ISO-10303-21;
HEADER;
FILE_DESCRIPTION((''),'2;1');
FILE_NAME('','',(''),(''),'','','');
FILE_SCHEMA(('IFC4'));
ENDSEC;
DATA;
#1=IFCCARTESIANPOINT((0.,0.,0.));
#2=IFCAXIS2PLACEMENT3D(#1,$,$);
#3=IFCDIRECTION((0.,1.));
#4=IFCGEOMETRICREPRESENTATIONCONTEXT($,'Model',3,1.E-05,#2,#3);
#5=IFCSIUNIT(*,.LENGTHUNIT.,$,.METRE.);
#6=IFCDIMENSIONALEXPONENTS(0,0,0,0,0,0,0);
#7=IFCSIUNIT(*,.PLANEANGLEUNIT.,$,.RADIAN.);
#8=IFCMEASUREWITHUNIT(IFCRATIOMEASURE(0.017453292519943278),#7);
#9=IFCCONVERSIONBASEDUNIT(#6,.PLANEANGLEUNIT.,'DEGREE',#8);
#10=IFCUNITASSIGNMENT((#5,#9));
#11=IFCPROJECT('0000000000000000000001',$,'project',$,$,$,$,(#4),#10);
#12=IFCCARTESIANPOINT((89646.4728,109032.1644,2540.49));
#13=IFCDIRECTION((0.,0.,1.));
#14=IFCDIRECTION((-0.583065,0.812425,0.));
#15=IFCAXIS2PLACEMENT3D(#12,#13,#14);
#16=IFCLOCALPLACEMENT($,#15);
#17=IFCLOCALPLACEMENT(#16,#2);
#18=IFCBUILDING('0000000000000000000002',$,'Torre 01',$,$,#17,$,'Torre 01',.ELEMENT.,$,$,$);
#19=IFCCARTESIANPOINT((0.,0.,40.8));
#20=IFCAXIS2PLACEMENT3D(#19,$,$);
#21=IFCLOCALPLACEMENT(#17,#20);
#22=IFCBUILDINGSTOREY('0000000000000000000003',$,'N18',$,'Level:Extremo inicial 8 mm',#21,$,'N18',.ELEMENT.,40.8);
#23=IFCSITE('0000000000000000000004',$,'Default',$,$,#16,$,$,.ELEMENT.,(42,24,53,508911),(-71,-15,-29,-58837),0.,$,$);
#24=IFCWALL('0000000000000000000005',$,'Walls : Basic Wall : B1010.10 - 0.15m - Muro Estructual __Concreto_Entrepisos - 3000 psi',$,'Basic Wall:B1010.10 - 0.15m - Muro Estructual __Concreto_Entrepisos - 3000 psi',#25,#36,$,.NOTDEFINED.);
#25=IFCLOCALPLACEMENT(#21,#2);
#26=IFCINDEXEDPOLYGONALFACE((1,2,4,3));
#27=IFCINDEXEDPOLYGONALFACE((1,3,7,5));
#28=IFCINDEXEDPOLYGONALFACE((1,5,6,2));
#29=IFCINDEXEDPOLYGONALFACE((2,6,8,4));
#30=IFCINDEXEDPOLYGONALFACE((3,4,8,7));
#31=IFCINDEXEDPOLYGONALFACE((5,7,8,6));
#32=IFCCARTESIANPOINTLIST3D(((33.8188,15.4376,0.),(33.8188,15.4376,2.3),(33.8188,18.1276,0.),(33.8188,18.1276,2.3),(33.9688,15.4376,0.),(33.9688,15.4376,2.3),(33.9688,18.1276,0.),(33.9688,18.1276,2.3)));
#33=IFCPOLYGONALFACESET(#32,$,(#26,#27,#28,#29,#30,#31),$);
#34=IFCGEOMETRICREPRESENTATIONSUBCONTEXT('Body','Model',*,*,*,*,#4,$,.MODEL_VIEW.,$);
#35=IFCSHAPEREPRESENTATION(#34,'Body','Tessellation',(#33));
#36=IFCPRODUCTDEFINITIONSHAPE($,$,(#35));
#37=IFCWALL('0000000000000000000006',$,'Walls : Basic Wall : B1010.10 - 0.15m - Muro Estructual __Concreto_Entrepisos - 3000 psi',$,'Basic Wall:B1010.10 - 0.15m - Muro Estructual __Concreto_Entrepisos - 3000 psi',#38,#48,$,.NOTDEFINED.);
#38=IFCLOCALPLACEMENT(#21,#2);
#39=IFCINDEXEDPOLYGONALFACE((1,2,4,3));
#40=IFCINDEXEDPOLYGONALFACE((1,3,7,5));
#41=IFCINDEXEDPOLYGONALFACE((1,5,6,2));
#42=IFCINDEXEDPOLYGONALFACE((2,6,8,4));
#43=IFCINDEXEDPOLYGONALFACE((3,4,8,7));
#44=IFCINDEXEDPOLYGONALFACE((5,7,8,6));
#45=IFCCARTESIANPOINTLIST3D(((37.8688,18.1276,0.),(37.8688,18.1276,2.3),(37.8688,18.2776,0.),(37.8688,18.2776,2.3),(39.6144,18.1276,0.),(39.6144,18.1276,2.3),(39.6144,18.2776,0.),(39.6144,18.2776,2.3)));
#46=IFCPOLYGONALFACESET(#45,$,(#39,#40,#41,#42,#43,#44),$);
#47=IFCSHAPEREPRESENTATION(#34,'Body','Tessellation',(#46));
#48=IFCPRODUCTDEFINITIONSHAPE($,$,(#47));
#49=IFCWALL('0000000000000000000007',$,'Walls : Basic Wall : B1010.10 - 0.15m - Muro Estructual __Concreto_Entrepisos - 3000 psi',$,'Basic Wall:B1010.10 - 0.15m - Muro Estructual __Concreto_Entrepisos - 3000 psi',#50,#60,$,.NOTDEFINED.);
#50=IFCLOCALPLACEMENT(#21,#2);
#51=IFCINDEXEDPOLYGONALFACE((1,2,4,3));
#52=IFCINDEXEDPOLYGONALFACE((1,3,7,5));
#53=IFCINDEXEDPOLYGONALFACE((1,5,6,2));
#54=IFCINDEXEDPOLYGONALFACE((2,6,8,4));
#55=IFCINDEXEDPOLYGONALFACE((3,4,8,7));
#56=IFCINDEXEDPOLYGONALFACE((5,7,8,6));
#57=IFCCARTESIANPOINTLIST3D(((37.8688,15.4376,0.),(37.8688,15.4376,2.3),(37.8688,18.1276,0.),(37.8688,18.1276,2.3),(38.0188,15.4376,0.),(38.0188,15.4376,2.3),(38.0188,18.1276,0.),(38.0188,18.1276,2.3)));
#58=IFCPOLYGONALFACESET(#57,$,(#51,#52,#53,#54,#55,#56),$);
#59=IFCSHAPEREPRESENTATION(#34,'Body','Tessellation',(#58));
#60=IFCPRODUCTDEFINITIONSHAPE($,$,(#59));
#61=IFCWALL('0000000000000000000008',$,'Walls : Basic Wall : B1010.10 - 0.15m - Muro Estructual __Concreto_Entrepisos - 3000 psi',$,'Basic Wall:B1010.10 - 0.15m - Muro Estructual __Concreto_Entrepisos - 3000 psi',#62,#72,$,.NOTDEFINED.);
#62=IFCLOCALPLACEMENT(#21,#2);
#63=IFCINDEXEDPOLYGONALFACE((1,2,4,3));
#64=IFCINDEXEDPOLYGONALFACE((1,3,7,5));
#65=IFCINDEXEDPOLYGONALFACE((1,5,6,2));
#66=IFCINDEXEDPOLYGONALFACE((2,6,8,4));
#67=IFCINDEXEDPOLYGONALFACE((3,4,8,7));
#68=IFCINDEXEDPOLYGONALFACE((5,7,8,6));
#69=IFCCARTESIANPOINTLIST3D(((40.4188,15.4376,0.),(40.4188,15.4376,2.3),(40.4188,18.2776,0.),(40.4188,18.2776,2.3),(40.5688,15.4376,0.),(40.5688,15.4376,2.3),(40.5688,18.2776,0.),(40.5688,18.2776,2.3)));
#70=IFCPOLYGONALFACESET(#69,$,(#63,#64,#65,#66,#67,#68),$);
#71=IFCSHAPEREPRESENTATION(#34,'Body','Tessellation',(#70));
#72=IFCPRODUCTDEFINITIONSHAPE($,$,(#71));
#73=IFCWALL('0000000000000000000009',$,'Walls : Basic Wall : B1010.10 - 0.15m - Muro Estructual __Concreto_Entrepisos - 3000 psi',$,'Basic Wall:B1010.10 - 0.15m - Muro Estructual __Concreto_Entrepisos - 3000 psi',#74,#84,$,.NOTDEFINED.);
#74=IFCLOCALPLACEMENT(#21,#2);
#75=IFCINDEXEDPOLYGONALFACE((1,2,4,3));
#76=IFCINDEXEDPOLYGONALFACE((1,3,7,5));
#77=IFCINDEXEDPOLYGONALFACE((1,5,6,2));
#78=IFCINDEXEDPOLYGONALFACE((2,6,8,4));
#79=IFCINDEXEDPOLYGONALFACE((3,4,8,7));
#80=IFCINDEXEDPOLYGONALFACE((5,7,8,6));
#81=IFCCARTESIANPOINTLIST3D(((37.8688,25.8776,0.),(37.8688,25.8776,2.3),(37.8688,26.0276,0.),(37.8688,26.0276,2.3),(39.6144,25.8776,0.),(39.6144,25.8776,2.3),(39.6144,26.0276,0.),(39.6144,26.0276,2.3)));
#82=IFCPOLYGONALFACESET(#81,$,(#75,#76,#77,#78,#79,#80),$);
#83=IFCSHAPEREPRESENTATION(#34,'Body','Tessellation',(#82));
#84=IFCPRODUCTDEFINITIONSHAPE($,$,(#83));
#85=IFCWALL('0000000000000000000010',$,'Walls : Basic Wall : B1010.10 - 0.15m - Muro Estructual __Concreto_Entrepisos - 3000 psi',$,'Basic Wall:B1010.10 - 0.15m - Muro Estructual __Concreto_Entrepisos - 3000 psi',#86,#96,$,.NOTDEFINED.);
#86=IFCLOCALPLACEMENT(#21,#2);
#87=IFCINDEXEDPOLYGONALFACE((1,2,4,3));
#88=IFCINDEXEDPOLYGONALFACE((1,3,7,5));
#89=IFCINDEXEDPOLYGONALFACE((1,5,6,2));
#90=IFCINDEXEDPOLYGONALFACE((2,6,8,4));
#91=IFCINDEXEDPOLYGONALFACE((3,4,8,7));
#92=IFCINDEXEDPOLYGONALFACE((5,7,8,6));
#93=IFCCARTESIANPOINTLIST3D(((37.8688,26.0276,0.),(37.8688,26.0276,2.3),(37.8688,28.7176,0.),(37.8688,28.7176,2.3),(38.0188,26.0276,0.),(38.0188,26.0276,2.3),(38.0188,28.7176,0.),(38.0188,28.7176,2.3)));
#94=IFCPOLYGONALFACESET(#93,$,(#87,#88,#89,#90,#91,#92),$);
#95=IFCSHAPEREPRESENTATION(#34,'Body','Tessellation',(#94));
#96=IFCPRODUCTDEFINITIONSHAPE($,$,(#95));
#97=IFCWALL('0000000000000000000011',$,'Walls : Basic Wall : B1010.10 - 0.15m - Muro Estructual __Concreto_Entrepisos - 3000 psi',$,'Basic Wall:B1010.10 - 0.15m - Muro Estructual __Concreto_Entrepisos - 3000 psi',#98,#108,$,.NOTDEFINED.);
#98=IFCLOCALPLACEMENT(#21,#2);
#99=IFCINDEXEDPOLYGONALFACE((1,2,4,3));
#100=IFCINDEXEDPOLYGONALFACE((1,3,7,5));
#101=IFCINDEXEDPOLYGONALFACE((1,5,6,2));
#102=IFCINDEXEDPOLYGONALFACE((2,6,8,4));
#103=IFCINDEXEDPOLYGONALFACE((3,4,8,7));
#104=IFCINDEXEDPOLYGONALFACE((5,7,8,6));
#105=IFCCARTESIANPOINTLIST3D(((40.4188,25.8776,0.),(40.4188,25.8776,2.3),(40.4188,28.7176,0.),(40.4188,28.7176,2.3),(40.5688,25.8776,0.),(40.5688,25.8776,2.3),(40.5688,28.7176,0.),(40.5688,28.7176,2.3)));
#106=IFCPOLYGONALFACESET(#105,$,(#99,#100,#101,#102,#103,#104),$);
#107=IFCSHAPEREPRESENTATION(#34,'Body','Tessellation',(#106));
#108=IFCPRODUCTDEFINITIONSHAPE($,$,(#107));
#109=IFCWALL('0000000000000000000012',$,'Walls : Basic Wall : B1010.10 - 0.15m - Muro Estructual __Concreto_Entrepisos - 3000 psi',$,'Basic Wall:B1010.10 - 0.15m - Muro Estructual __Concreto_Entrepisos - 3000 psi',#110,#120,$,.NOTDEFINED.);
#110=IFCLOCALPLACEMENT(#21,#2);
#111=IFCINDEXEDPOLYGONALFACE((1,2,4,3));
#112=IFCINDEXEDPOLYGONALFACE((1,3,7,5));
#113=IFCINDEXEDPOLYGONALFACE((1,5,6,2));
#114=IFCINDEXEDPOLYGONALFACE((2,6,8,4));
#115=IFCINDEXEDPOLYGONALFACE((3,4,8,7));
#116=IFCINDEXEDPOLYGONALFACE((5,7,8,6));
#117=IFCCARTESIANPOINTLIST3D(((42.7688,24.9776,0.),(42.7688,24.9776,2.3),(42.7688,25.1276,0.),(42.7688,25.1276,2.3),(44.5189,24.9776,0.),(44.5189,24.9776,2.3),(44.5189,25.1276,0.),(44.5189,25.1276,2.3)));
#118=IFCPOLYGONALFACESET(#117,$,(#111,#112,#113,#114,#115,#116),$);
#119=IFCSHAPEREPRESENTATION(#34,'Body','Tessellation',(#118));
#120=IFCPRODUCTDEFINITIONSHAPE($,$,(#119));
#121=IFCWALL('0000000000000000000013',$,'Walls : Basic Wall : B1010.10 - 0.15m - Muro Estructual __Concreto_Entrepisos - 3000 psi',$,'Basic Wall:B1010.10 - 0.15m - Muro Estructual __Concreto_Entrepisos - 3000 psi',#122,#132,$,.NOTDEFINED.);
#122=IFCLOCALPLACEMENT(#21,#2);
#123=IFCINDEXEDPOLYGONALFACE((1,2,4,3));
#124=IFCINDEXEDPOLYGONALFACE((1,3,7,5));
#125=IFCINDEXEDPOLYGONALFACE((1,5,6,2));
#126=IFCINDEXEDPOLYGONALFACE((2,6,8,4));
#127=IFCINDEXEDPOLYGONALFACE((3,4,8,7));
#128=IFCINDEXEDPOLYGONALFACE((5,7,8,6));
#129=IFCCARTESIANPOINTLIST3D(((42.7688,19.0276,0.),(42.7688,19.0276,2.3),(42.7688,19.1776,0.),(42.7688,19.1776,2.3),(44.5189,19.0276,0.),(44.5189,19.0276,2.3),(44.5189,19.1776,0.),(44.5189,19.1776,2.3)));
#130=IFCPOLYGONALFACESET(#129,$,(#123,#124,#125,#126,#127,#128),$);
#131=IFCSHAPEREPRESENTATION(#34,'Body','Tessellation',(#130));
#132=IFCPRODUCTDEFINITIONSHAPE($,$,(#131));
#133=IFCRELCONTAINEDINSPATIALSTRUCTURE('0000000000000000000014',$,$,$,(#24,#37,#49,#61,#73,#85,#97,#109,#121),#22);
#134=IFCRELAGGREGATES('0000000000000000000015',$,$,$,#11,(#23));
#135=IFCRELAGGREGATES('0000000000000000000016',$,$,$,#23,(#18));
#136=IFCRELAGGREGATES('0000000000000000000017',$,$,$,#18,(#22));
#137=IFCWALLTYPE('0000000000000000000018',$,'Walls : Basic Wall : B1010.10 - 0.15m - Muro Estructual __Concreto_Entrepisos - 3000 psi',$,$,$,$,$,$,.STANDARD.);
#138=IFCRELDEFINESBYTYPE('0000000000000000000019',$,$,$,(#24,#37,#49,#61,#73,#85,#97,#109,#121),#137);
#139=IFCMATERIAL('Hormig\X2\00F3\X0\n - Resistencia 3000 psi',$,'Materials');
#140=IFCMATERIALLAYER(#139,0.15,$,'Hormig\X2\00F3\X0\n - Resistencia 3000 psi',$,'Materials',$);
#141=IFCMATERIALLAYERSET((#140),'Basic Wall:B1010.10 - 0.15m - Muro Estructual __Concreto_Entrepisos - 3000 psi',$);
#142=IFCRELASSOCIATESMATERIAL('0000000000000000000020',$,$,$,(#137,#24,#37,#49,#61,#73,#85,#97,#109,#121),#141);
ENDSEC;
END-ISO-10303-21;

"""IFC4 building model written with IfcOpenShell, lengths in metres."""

from ifc_helpers import new_model, entity, si_unit, converted_unit, direction, frame, frame_2d, origin, place, context, subcontext, project, spatial, rectangle, extrude, material, layer, layer_set, layer_usage, type_object, element, save


model = new_model("IFC4")

# Units and contexts
model_context = context("Model", 3, precision=1e-05, world=origin(), true_north=direction((0.0, 1.0)))
body_context = subcontext(model_context, "Body", "Model", "MODEL_VIEW")
ifc_project = project(units=[si_unit("LENGTHUNIT", "METRE"), converted_unit("PLANEANGLEUNIT", "DEGREE", entity("IfcRatioMeasure", 0.017453292519943278), si_unit("PLANEANGLEUNIT", "RADIAN"), dimensions=[0, 0, 0, 0, 0, 0, 0])], contexts=[model_context])

# Site, building, storey
site_placement = place(None, frame((89646.4728, 109032.1644, 2540.49), z_axis=(0.0, 0.0, 1.0), x_axis=(-0.583065, 0.812425, 0.0)))
site = spatial("IfcSite", under=ifc_project, at=site_placement, Name="Default", CompositionType="ELEMENT", RefLatitude=(42, 24, 53, 508911), RefLongitude=(-71, -15, -29, -58837), RefElevation=0.0)
building_placement = place(site_placement, origin())
building = spatial("IfcBuilding", under=site, at=building_placement, Name="Torre 01", LongName="Torre 01", CompositionType="ELEMENT")
storey_placement = place(building_placement, frame((0.0, 0.0, 40.8)))
storey = spatial("IfcBuildingStorey", under=building, at=storey_placement, Name="N18", ObjectType="Level:Extremo inicial 8 mm", LongName="N18", CompositionType="ELEMENT", Elevation=40.8)

# Walls
ifc_material = material(Name="Hormigón - Resistencia 3000 psi", Category="Materials")
ifc_layer_1 = layer(ifc_material, 0.15, Name="Hormigón - Resistencia 3000 psi", Category="Materials")
ifc_layer_set_1 = layer_set([ifc_layer_1], Name="Basic Wall:B1010.10 - 0.15m - Muro Estructual __Concreto_Entrepisos - 3000 psi")
wall_type_1 = type_object("IfcWallType", Name="Walls : Basic Wall : B1010.10 - 0.15m - Muro Estructual __Concreto_Entrepisos - 3000 psi", PredefinedType="STANDARD", material=ifc_layer_set_1)
ifc_layer_usage_1 = layer_usage(ifc_layer_set_1, "AXIS2", "NEGATIVE", 0.075)
wall_1_placement = place(storey_placement, frame((33.8938, 18.1276, 0.0), z_axis=(0.0, 0.0, 1.0), x_axis=(0.0, -1.0, 0.0)))
element("IfcWall", 1, at=wall_1_placement, inside=storey, type_object=wall_type_1, material=ifc_layer_usage_1, Name="Walls : Basic Wall : B1010.10 - 0.15m - Muro Estructual __Concreto_Entrepisos - 3000 psi", ObjectType="Basic Wall:B1010.10 - 0.15m - Muro Estructual __Concreto_Entrepisos - 3000 psi", PredefinedType="NOTDEFINED", context=body_context, shape_type="SweptSolid", body=[
    extrude(rectangle(XDim=2.69, YDim=0.15, at=frame_2d((1.345, 0.0), x_axis=(-1.0, 0.0))), origin(), (0.0, 0.0, 1.0), 2.3),
])
ifc_layer_usage_2 = layer_usage(ifc_layer_set_1, "AXIS2", "NEGATIVE", 0.075)
wall_2_placement = place(storey_placement, frame((39.6144, 18.2026, 0.0), z_axis=(0.0, 0.0, 1.0), x_axis=(-1.0, 0.0, 0.0)))
element("IfcWall", 2, at=wall_2_placement, inside=storey, type_object=wall_type_1, material=ifc_layer_usage_2, Name="Walls : Basic Wall : B1010.10 - 0.15m - Muro Estructual __Concreto_Entrepisos - 3000 psi", ObjectType="Basic Wall:B1010.10 - 0.15m - Muro Estructual __Concreto_Entrepisos - 3000 psi", PredefinedType="NOTDEFINED", context=body_context, shape_type="SweptSolid", body=[
    extrude(rectangle(XDim=1.7455, YDim=0.15, at=frame_2d((0.8728, 0.0), x_axis=(-1.0, 0.0))), origin(), (0.0, 0.0, 1.0), 2.3),
])
ifc_layer_usage_3 = layer_usage(ifc_layer_set_1, "AXIS2", "NEGATIVE", 0.075)
wall_3_placement = place(storey_placement, frame((37.9438, 18.1276, 0.0), z_axis=(0.0, 0.0, 1.0), x_axis=(0.0, -1.0, 0.0)))
element("IfcWall", 3, at=wall_3_placement, inside=storey, type_object=wall_type_1, material=ifc_layer_usage_3, Name="Walls : Basic Wall : B1010.10 - 0.15m - Muro Estructual __Concreto_Entrepisos - 3000 psi", ObjectType="Basic Wall:B1010.10 - 0.15m - Muro Estructual __Concreto_Entrepisos - 3000 psi", PredefinedType="NOTDEFINED", context=body_context, shape_type="SweptSolid", body=[
    extrude(rectangle(XDim=2.69, YDim=0.15, at=frame_2d((1.345, 0.0), x_axis=(-1.0, 0.0))), origin(), (0.0, 0.0, 1.0), 2.3),
])
ifc_layer_usage_4 = layer_usage(ifc_layer_set_1, "AXIS2", "NEGATIVE", 0.075)
wall_4_placement = place(storey_placement, frame((40.4938, 18.2776, 0.0), z_axis=(0.0, 0.0, 1.0), x_axis=(0.0, -1.0, 0.0)))
element("IfcWall", 4, at=wall_4_placement, inside=storey, type_object=wall_type_1, material=ifc_layer_usage_4, Name="Walls : Basic Wall : B1010.10 - 0.15m - Muro Estructual __Concreto_Entrepisos - 3000 psi", ObjectType="Basic Wall:B1010.10 - 0.15m - Muro Estructual __Concreto_Entrepisos - 3000 psi", PredefinedType="NOTDEFINED", context=body_context, shape_type="SweptSolid", body=[
    extrude(rectangle(XDim=2.84, YDim=0.15, at=frame_2d((1.42, 0.0), x_axis=(-1.0, 0.0))), origin(), (0.0, 0.0, 1.0), 2.3),
])
ifc_layer_usage_5 = layer_usage(ifc_layer_set_1, "AXIS2", "POSITIVE", -0.075)
wall_5_placement = place(storey_placement, frame((39.6144, 25.9526, 0.0), z_axis=(0.0, 0.0, 1.0), x_axis=(-1.0, 0.0, 0.0)))
element("IfcWall", 5, at=wall_5_placement, inside=storey, type_object=wall_type_1, material=ifc_layer_usage_5, Name="Walls : Basic Wall : B1010.10 - 0.15m - Muro Estructual __Concreto_Entrepisos - 3000 psi", ObjectType="Basic Wall:B1010.10 - 0.15m - Muro Estructual __Concreto_Entrepisos - 3000 psi", PredefinedType="NOTDEFINED", context=body_context, shape_type="SweptSolid", body=[
    extrude(rectangle(XDim=1.7455, YDim=0.15, at=frame_2d((0.8728, 0.0), x_axis=(-1.0, 0.0))), origin(), (0.0, 0.0, 1.0), 2.3),
])
ifc_layer_usage_6 = layer_usage(ifc_layer_set_1, "AXIS2", "POSITIVE", -0.075)
wall_6_placement = place(storey_placement, frame((37.9438, 26.0276, 0.0), z_axis=(0.0, 0.0, 1.0), x_axis=(0.0, 1.0, 0.0)))
element("IfcWall", 6, at=wall_6_placement, inside=storey, type_object=wall_type_1, material=ifc_layer_usage_6, Name="Walls : Basic Wall : B1010.10 - 0.15m - Muro Estructual __Concreto_Entrepisos - 3000 psi", ObjectType="Basic Wall:B1010.10 - 0.15m - Muro Estructual __Concreto_Entrepisos - 3000 psi", PredefinedType="NOTDEFINED", context=body_context, shape_type="SweptSolid", body=[
    extrude(rectangle(XDim=2.69, YDim=0.15, at=frame_2d((1.345, 0.0), x_axis=(-1.0, 0.0))), origin(), (0.0, 0.0, 1.0), 2.3),
])
ifc_layer_usage_7 = layer_usage(ifc_layer_set_1, "AXIS2", "POSITIVE", -0.075)
wall_7_placement = place(storey_placement, frame((40.4938, 25.8776, 0.0), z_axis=(0.0, 0.0, 1.0), x_axis=(0.0, 1.0, 0.0)))
element("IfcWall", 7, at=wall_7_placement, inside=storey, type_object=wall_type_1, material=ifc_layer_usage_7, Name="Walls : Basic Wall : B1010.10 - 0.15m - Muro Estructual __Concreto_Entrepisos - 3000 psi", ObjectType="Basic Wall:B1010.10 - 0.15m - Muro Estructual __Concreto_Entrepisos - 3000 psi", PredefinedType="NOTDEFINED", context=body_context, shape_type="SweptSolid", body=[
    extrude(rectangle(XDim=2.84, YDim=0.15, at=frame_2d((1.42, 0.0), x_axis=(-1.0, 0.0))), origin(), (0.0, 0.0, 1.0), 2.3),
])
ifc_layer_usage_8 = layer_usage(ifc_layer_set_1, "AXIS2", "NEGATIVE", 0.075)
wall_8_placement = place(storey_placement, frame((42.7688, 25.0526, 0.0)))
element("IfcWall", 8, at=wall_8_placement, inside=storey, type_object=wall_type_1, material=ifc_layer_usage_8, Name="Walls : Basic Wall : B1010.10 - 0.15m - Muro Estructual __Concreto_Entrepisos - 3000 psi", ObjectType="Basic Wall:B1010.10 - 0.15m - Muro Estructual __Concreto_Entrepisos - 3000 psi", PredefinedType="NOTDEFINED", context=body_context, shape_type="SweptSolid", body=[
    extrude(rectangle(XDim=1.75, YDim=0.15, at=frame_2d((0.875, 0.0), x_axis=(-1.0, 0.0))), origin(), (0.0, 0.0, 1.0), 2.3),
])
ifc_layer_usage_9 = layer_usage(ifc_layer_set_1, "AXIS2", "POSITIVE", -0.075)
wall_9_placement = place(storey_placement, frame((42.7688, 19.1026, 0.0)))
element("IfcWall", 9, at=wall_9_placement, inside=storey, type_object=wall_type_1, material=ifc_layer_usage_9, Name="Walls : Basic Wall : B1010.10 - 0.15m - Muro Estructual __Concreto_Entrepisos - 3000 psi", ObjectType="Basic Wall:B1010.10 - 0.15m - Muro Estructual __Concreto_Entrepisos - 3000 psi", PredefinedType="NOTDEFINED", context=body_context, shape_type="SweptSolid", body=[
    extrude(rectangle(XDim=1.75, YDim=0.15, at=frame_2d((0.875, 0.0), x_axis=(-1.0, 0.0))), origin(), (0.0, 0.0, 1.0), 2.3),
])

save(model, "model.ifc")
